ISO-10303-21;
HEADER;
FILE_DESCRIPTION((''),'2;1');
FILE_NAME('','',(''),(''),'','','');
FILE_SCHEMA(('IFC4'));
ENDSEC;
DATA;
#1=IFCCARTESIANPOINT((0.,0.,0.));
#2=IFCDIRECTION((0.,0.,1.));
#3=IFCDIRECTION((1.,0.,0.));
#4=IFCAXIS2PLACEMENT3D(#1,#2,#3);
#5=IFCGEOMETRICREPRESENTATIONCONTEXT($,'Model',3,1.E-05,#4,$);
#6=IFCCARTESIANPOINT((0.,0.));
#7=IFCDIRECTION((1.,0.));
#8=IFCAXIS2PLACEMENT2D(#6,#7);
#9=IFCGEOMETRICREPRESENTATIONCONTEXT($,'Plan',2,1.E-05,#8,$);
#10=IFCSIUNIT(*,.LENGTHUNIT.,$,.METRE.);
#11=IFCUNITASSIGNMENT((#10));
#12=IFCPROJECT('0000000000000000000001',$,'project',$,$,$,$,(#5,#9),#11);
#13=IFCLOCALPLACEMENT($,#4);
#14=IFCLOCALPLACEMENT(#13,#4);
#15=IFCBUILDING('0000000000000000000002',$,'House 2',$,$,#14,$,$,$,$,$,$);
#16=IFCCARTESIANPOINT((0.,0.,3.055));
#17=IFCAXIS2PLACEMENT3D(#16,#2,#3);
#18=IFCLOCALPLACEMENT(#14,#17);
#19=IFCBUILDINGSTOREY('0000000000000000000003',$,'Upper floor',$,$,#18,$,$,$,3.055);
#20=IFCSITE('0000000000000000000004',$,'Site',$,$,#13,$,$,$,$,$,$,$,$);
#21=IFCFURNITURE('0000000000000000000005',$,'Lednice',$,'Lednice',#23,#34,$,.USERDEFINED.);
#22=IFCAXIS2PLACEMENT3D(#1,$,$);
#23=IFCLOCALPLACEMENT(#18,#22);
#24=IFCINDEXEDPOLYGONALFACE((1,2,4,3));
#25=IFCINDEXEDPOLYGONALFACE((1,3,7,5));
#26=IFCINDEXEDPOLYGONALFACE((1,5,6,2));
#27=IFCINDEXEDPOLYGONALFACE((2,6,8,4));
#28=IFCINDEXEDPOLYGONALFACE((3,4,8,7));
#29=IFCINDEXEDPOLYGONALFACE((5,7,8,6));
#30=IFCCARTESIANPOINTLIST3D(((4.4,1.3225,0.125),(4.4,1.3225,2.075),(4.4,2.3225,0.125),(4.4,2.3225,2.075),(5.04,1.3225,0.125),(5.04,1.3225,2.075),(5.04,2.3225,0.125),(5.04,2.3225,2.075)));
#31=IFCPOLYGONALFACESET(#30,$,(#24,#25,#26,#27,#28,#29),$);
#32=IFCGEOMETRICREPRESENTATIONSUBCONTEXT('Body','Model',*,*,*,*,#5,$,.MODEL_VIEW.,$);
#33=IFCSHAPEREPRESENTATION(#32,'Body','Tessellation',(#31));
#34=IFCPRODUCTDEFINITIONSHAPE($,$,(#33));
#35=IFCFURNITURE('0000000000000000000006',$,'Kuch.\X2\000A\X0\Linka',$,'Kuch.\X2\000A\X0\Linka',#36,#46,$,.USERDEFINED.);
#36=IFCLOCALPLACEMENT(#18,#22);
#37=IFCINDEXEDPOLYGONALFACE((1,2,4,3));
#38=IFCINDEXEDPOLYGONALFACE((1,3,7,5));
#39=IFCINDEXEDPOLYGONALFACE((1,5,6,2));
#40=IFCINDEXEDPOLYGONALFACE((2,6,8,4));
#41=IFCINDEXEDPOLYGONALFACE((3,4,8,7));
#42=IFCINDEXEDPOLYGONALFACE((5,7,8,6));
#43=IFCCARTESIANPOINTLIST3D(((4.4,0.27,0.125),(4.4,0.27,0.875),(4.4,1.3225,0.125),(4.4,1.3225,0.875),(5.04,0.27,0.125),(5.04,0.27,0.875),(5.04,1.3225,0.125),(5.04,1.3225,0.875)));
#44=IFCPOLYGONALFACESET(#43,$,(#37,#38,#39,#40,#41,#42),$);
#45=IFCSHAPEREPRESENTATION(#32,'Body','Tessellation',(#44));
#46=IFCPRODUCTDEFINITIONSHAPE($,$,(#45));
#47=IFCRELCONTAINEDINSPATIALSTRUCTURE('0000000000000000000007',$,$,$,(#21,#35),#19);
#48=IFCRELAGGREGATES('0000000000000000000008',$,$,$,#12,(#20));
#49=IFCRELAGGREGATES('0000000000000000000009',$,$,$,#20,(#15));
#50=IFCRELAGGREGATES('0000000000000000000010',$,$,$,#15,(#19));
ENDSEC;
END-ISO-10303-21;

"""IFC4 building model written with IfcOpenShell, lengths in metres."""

from ifc_helpers import new_model, entity, si_unit, frame, origin_with_axes, origin_2d_with_axis, place, context, subcontext, project, spatial, indexed_curve, outline, extrude, shape, element, save


model = new_model("IFC4")

# Units and contexts
model_context = context("Model", 3, precision=1e-05, world=origin_with_axes())
plan_context = context("Plan", 2, precision=1e-05, world=origin_2d_with_axis())
body_context_1 = subcontext(model_context, "Body", "Model", "MODEL_VIEW")
body_context_2 = subcontext(plan_context, "Body", "Plan", "PLAN_VIEW")
ifc_project = project(units=[si_unit("LENGTHUNIT", "METRE")], contexts=[model_context, plan_context])

# Site, building, storey
site_placement = place(None, origin_with_axes())
site = spatial("IfcSite", under=ifc_project, at=site_placement, Name="Site")
building_placement = place(site_placement, origin_with_axes())
building = spatial("IfcBuilding", under=site, at=building_placement, Name="House 2")
storey_placement = place(building_placement, frame((0.0, 0.0, 3.055), z_axis=(0.0, 0.0, 1.0), x_axis=(1.0, 0.0, 0.0)))
storey = spatial("IfcBuildingStorey", under=building, at=storey_placement, Name="Upper floor", Elevation=3.055)

# Furniture
furniture_1_placement = place(storey_placement, frame((4.72, 1.8225, 0.125), z_axis=(0.0, 0.0, 1.0), x_axis=(1.0, 0.0, 0.0)))
element("IfcFurniture", 1, at=furniture_1_placement, inside=storey, Name="Lednice", ObjectType="Lednice", PredefinedType="USERDEFINED", shapes=[
    shape(body_context_1, "Body", "SweptSolid", [extrude(outline(indexed_curve([(-0.32, -0.5), (0.32, -0.5), (0.32, 0.5), (-0.32, 0.5)])), None, (0.0, 0.0, 1.0), 1.95)]),
    shape(body_context_2, "Body", "Curve2D", [entity("IfcIndexedPolyCurve", entity("IfcCartesianPointList2D", [[-0.32, -0.5], [0.32, -0.5], [0.32, 0.5], [-0.32, 0.5], [-0.32, -0.5]]), None, False)]),
])
furniture_2_placement = place(storey_placement, frame((4.72, 0.7963, 0.125), z_axis=(0.0, 0.0, 1.0), x_axis=(1.0, 0.0, 0.0)))
element("IfcFurniture", 2, at=furniture_2_placement, inside=storey, Name="Kuch.\nLinka", ObjectType="Kuch.\nLinka", PredefinedType="USERDEFINED", shapes=[
    shape(body_context_1, "Body", "SweptSolid", [extrude(outline(indexed_curve([(-0.32, -0.5263), (0.32, -0.5263), (0.32, 0.5263), (-0.32, 0.5263)])), None, (0.0, 0.0, 1.0), 0.75)]),
    shape(body_context_2, "Body", "Curve2D", [entity("IfcIndexedPolyCurve", entity("IfcCartesianPointList2D", [[-0.32, -0.5263], [0.32, -0.5263], [0.32, 0.5263], [-0.32, 0.5263], [-0.32, -0.5263]]), None, False)]),
])

save(model, "model.ifc")
